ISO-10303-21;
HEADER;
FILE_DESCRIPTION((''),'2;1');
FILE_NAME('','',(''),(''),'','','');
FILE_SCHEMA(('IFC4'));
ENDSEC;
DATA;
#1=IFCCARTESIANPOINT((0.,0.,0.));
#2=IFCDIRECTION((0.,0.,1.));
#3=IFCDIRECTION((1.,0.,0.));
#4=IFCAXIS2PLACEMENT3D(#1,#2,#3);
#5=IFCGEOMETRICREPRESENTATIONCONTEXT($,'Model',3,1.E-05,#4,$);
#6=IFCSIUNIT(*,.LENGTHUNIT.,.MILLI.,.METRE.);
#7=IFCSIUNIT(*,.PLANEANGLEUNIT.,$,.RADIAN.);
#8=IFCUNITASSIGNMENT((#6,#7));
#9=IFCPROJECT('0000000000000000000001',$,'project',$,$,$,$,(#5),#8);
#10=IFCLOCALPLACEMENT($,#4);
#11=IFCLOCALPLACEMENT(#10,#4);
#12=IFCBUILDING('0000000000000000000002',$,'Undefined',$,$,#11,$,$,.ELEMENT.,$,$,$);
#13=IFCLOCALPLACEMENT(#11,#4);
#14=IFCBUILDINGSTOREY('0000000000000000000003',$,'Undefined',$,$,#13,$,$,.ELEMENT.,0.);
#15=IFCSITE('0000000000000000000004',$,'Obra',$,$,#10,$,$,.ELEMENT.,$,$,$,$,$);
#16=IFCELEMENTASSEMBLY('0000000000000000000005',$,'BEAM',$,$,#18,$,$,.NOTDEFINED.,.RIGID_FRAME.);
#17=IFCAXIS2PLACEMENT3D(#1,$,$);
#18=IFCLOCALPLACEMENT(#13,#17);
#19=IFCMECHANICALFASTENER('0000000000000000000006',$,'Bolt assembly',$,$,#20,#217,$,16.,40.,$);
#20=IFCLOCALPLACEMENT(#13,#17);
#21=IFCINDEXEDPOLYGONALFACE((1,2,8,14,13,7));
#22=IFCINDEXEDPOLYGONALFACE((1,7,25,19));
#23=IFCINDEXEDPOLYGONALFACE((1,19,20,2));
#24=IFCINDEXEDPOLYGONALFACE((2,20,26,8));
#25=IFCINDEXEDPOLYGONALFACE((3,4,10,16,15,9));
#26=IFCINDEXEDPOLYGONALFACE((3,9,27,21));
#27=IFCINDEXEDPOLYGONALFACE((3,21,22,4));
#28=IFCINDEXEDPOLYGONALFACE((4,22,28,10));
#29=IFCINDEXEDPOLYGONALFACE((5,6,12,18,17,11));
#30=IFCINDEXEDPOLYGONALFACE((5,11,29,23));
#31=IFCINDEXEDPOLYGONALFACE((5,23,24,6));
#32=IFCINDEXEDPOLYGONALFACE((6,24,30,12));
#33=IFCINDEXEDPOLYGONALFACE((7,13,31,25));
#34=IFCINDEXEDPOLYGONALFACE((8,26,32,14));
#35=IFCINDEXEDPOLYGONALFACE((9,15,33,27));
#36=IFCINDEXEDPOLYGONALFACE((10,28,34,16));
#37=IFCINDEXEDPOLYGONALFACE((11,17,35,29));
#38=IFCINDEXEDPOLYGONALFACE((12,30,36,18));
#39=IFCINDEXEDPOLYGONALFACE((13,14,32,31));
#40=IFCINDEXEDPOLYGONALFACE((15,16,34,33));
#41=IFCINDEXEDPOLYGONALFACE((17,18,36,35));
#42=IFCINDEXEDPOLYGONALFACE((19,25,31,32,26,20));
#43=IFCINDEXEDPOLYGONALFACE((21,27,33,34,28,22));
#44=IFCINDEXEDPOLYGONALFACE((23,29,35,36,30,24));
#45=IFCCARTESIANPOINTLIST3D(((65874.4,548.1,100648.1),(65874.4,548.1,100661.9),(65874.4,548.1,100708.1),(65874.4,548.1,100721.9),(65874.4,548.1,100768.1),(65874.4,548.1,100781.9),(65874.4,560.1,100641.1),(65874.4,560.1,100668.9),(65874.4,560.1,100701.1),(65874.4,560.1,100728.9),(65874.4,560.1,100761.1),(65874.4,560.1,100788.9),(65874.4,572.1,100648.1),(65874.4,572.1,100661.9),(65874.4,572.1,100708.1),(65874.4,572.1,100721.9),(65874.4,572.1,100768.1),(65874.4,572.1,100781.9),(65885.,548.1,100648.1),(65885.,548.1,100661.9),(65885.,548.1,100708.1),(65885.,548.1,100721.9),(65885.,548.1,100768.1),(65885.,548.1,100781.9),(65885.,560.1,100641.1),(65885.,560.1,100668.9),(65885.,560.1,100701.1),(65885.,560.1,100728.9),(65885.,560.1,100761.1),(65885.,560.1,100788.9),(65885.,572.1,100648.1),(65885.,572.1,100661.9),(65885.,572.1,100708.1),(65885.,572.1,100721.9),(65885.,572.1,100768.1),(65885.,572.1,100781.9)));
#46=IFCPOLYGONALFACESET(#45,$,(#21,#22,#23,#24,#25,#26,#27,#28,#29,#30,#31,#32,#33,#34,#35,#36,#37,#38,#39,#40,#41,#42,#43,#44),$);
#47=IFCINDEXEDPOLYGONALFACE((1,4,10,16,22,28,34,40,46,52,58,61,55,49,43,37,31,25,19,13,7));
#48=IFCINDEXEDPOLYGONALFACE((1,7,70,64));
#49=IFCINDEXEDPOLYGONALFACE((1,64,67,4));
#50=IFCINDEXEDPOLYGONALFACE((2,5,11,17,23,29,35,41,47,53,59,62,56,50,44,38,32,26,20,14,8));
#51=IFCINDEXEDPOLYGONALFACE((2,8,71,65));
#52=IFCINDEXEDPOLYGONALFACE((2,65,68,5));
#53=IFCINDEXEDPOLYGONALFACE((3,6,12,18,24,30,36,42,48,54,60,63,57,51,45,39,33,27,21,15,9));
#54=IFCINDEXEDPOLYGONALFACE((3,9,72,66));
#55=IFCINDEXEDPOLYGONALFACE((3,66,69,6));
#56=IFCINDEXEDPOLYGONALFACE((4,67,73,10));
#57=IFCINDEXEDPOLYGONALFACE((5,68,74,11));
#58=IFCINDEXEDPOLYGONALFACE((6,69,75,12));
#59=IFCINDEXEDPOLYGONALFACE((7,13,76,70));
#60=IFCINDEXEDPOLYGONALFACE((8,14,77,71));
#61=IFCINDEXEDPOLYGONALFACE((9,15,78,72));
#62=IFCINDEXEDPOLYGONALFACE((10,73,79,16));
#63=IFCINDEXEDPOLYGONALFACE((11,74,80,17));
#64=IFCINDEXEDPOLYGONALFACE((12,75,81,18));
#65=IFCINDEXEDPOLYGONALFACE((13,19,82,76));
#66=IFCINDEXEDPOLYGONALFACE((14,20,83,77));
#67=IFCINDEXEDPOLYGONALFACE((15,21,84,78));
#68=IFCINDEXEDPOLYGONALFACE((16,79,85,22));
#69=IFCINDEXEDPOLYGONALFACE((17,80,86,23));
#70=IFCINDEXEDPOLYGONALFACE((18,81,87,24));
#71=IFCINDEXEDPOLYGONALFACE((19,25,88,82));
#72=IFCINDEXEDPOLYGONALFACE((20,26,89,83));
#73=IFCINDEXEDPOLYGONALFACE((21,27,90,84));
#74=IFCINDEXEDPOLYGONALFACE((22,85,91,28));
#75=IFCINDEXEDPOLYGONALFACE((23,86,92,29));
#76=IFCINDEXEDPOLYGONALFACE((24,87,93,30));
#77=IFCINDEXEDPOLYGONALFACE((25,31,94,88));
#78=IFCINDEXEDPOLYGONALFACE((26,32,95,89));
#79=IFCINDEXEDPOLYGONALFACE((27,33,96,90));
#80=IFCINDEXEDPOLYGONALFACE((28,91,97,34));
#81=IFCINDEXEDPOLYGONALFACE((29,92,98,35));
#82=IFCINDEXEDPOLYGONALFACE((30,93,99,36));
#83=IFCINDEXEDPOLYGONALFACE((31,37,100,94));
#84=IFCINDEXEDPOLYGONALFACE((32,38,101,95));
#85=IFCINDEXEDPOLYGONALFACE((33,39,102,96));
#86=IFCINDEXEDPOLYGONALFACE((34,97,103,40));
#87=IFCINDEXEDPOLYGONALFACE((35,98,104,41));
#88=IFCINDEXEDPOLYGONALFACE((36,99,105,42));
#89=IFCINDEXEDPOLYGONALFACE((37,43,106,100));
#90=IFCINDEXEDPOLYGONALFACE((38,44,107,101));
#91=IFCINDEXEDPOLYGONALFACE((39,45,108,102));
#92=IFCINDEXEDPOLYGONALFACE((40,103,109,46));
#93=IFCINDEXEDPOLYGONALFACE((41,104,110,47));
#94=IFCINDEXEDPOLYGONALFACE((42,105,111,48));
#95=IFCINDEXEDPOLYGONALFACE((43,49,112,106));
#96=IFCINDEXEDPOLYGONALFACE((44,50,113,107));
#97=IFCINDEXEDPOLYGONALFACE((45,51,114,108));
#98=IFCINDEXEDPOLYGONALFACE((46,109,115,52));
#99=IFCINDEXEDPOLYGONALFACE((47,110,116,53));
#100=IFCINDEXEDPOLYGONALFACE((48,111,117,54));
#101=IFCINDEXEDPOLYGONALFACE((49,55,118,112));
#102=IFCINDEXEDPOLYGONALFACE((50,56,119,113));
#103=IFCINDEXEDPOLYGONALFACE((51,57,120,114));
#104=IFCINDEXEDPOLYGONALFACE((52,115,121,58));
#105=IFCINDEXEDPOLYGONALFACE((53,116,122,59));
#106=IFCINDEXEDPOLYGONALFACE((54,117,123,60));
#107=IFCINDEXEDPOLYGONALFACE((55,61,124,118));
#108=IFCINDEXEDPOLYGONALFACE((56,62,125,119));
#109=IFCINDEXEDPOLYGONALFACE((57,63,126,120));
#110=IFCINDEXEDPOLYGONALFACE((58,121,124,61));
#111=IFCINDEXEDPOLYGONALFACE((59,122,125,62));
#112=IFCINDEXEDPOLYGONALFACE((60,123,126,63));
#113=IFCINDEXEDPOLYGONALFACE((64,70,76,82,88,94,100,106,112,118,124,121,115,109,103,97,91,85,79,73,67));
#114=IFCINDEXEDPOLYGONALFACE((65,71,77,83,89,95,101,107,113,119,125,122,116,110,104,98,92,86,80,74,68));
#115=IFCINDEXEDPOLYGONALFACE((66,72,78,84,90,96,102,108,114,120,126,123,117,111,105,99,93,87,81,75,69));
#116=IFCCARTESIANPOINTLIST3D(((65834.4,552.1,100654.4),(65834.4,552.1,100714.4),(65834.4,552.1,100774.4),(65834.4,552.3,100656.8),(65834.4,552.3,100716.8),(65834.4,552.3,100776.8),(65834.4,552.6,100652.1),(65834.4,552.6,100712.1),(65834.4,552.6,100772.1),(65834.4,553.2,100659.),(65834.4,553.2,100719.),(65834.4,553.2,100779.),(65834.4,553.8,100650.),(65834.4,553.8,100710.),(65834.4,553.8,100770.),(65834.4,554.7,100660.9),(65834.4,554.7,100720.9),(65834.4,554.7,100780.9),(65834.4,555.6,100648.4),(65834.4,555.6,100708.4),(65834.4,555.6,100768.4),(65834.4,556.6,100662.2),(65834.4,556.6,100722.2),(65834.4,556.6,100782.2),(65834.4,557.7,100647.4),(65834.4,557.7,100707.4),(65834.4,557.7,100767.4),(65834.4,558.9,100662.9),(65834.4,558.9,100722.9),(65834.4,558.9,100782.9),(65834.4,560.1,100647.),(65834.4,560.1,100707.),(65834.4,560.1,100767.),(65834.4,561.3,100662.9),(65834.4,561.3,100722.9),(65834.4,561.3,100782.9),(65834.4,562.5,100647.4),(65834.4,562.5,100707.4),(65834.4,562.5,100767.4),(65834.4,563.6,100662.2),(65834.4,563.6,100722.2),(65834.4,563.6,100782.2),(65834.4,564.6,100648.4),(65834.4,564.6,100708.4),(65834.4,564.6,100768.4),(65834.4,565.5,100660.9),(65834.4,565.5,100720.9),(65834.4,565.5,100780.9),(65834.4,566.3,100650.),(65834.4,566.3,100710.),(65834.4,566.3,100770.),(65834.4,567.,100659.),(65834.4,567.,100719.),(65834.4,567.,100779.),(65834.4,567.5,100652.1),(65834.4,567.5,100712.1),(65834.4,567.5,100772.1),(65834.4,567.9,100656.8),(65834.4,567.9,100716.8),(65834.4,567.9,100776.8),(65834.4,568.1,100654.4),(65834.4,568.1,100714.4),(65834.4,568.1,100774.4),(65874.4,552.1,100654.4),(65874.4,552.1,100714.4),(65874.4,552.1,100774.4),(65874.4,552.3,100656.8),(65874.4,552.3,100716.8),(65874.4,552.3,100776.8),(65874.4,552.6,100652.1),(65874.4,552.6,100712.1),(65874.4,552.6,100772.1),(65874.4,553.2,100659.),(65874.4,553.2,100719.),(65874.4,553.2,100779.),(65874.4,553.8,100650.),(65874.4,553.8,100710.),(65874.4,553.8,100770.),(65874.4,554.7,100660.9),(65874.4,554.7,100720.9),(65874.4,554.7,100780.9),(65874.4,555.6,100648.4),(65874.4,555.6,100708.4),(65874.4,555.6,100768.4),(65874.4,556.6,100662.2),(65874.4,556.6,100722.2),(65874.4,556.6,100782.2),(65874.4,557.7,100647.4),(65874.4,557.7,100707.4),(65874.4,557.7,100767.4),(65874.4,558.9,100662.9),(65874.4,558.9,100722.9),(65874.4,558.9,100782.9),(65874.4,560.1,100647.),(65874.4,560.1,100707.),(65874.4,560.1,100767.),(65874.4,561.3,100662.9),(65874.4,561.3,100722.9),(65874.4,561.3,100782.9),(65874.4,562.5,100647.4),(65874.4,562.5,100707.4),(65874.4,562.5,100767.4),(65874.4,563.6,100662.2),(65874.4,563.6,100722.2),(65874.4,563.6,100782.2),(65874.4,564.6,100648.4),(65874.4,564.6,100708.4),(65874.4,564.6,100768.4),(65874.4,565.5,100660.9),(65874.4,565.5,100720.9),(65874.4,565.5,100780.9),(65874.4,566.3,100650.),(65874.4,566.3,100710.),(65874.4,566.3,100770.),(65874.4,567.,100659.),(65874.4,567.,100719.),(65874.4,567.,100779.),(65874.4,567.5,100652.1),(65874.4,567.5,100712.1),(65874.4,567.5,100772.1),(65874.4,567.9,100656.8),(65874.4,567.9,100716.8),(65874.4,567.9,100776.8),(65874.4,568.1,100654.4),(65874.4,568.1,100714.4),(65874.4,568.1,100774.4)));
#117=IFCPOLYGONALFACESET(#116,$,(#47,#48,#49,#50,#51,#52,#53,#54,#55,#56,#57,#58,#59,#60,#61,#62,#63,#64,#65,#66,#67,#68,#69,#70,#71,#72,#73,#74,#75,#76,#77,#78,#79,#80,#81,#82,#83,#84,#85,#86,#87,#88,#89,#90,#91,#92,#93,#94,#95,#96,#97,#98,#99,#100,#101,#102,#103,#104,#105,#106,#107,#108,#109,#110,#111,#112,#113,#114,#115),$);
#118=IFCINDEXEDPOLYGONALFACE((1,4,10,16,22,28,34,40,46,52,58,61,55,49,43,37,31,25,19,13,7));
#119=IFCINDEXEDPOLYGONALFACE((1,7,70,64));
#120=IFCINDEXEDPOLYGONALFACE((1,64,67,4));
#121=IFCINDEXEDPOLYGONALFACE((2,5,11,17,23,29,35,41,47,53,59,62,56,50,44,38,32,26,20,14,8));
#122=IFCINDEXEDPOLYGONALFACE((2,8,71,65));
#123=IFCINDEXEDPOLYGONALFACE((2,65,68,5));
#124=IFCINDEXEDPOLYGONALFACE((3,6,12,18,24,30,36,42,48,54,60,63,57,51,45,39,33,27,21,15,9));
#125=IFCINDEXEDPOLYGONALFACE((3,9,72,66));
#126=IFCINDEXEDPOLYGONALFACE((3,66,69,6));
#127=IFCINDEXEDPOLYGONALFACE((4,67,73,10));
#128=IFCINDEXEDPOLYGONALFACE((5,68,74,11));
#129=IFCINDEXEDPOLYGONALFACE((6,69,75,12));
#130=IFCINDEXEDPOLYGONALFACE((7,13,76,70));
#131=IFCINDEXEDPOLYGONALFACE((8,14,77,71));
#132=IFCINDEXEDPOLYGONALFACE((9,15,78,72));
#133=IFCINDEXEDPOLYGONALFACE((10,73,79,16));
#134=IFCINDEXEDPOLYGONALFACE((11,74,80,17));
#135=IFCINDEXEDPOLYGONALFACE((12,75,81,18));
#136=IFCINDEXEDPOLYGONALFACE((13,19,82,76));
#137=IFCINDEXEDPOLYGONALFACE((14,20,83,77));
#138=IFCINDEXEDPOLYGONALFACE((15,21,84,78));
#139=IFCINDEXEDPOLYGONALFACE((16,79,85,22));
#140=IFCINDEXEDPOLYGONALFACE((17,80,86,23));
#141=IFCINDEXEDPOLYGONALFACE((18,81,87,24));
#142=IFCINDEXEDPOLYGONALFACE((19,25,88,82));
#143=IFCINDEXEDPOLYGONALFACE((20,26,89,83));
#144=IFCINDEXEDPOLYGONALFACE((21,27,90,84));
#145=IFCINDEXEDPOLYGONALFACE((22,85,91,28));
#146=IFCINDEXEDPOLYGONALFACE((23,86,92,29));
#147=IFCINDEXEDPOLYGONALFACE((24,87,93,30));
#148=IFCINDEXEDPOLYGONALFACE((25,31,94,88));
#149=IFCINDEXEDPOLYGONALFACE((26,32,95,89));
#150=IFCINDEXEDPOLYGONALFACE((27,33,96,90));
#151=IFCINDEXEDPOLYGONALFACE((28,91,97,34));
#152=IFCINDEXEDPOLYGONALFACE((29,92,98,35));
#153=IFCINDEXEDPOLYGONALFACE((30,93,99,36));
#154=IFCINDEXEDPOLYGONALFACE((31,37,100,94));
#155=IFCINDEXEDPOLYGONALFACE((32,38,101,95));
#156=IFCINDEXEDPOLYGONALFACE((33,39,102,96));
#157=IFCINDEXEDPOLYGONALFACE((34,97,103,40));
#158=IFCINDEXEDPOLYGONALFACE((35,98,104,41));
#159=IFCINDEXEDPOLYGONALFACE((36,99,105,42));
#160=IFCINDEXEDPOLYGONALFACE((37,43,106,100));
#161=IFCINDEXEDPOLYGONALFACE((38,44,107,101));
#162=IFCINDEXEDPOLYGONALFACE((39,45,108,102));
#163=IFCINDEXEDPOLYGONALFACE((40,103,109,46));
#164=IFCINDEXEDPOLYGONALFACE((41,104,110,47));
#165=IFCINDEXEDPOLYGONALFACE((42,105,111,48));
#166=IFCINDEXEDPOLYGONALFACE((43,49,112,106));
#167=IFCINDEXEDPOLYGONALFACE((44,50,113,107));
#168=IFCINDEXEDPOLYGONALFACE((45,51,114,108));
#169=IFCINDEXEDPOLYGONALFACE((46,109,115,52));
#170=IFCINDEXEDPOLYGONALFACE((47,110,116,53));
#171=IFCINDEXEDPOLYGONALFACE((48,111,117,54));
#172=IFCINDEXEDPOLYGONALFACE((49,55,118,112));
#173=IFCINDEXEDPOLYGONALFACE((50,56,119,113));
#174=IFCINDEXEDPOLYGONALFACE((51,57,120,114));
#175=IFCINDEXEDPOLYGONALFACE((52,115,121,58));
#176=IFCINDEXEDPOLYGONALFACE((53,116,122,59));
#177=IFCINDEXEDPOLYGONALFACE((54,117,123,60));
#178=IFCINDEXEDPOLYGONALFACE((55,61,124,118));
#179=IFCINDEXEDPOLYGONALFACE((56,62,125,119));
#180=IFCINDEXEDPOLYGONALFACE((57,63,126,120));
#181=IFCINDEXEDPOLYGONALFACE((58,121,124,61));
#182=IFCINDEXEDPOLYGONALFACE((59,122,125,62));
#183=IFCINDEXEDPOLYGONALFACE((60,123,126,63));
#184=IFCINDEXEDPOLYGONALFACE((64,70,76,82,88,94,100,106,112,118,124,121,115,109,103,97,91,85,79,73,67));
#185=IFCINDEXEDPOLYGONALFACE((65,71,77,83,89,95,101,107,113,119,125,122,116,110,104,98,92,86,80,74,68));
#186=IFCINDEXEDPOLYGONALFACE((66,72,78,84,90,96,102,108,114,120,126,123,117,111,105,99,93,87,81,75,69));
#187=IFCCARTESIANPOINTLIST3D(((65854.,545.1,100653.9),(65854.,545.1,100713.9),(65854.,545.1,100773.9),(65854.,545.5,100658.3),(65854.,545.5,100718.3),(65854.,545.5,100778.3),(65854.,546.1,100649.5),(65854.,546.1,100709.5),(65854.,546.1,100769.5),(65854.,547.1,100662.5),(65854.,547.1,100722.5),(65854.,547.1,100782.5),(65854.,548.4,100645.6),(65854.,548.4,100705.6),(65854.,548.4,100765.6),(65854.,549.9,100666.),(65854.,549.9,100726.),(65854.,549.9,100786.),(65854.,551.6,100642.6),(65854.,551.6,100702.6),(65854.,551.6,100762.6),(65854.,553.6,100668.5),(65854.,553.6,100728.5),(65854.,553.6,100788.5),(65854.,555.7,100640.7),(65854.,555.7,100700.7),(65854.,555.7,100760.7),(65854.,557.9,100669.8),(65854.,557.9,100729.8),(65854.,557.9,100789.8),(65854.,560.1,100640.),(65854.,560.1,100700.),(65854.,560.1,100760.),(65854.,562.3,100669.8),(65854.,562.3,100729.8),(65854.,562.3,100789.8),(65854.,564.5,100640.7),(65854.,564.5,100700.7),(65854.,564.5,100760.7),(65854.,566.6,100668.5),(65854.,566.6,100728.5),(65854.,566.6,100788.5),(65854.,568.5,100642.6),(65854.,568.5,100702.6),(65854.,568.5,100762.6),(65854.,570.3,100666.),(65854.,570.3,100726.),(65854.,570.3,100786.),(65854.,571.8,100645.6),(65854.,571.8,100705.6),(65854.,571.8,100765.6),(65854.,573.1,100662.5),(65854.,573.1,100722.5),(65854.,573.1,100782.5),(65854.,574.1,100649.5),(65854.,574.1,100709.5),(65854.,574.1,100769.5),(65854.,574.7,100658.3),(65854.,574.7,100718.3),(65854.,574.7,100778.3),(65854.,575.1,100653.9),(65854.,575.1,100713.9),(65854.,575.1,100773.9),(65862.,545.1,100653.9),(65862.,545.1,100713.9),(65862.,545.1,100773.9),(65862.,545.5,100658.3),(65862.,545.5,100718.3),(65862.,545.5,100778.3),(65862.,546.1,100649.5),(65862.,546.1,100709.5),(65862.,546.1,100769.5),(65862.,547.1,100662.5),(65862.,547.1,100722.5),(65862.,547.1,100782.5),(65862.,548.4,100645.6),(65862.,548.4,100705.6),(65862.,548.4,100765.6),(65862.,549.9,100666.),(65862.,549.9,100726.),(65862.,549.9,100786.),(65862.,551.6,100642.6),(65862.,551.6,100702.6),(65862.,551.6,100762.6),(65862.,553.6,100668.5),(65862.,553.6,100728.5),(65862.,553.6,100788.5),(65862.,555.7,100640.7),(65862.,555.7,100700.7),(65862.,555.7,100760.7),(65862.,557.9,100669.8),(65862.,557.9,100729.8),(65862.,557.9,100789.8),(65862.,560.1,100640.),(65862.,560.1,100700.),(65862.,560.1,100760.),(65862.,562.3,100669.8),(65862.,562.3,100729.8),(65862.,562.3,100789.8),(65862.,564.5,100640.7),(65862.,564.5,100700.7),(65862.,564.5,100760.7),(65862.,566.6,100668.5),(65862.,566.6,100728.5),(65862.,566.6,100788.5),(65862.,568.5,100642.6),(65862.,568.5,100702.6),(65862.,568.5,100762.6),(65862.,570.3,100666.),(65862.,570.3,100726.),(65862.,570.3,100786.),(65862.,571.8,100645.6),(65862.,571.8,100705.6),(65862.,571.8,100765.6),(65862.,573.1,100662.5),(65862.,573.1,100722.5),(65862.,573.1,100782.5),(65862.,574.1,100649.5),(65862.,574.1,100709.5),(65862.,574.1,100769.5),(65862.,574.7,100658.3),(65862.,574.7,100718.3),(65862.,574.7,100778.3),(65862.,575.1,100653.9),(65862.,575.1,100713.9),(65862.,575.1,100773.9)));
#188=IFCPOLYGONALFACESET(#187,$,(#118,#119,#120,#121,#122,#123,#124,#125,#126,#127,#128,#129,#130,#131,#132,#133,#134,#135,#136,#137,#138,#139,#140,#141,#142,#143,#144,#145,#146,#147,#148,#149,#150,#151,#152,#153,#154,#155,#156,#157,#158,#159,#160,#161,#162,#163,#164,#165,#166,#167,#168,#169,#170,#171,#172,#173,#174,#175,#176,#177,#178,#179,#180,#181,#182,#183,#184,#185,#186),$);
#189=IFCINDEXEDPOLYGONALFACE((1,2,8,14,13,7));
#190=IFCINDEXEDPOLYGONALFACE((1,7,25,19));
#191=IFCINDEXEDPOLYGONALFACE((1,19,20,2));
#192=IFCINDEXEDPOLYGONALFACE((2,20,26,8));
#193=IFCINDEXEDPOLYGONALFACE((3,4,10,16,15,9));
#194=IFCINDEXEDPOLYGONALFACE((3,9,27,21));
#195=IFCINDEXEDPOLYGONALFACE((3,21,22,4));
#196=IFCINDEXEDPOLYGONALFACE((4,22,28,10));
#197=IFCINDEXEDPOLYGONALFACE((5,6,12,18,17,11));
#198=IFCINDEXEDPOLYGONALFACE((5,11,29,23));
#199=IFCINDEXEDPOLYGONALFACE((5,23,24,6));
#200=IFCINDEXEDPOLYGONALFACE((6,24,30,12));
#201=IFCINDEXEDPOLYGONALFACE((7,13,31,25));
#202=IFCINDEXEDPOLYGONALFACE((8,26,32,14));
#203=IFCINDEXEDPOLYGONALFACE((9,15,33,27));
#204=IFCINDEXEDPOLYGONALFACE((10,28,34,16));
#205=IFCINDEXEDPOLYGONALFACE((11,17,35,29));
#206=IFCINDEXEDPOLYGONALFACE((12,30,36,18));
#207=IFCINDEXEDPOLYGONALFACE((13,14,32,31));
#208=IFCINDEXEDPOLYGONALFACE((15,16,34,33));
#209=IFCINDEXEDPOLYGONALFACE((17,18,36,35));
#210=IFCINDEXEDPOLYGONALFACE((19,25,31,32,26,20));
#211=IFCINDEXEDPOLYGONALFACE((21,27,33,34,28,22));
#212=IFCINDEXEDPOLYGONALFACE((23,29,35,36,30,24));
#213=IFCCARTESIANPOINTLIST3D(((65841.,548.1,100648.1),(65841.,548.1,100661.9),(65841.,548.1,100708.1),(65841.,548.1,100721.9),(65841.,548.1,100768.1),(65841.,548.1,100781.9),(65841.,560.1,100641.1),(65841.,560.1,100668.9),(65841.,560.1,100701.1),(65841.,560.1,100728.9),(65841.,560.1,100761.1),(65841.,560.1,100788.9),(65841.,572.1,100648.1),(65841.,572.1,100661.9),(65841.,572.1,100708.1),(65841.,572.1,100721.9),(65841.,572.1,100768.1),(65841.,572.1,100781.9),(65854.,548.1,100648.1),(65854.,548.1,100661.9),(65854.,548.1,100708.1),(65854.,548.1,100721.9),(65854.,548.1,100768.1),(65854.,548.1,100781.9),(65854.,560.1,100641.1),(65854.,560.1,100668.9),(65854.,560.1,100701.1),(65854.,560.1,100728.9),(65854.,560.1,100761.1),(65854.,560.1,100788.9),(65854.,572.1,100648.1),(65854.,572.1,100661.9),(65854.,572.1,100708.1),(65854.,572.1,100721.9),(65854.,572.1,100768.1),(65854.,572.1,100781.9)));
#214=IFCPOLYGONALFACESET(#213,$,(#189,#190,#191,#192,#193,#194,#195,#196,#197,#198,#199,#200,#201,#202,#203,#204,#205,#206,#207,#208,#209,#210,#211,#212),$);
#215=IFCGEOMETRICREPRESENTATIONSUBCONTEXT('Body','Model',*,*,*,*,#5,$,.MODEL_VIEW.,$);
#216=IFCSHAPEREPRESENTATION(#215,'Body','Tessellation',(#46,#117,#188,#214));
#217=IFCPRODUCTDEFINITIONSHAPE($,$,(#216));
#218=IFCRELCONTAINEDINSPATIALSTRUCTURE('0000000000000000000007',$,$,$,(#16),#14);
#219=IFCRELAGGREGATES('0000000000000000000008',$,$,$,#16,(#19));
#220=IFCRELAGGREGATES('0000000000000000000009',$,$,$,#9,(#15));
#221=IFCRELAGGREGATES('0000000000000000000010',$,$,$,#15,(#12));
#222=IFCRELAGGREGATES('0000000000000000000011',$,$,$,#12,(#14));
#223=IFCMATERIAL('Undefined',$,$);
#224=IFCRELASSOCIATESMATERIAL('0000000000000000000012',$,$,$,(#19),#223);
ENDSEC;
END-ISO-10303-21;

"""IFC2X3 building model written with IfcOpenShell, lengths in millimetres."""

from ifc_helpers import new_model, si_unit, frame, origin_with_axes, origin_2d_with_axis, place, context, subcontext, project, spatial, polyline, circle, outline, extrude, source, transform, mapped, material, element, aggregate, save


model = new_model("IFC2X3")

# Units and contexts
model_context = context("Model", 3, precision=1e-05, world=origin_with_axes())
body_context = subcontext(model_context, "Body", "Model", "MODEL_VIEW")
ifc_project = project(units=[si_unit("LENGTHUNIT", "METRE", prefix="MILLI"), si_unit("PLANEANGLEUNIT", "RADIAN")], contexts=[model_context])

# Site, building, storey
site_placement = place(None, origin_with_axes())
site = spatial("IfcSite", under=ifc_project, at=site_placement, Name="Obra", CompositionType="ELEMENT")
building_placement = place(site_placement, origin_with_axes())
building = spatial("IfcBuilding", under=site, at=building_placement, Name="Undefined", CompositionType="ELEMENT")
storey_placement = place(building_placement, origin_with_axes())
storey = spatial("IfcBuildingStorey", under=building, at=storey_placement, Name="Undefined", CompositionType="ELEMENT", Elevation=0.0)

# Shared definitions
ifc_material_1 = material(Name="Undefined")

# Element assembly, mechanical fastener
assembly_1_placement = place(storey_placement, origin_with_axes())
assembly_1 = element("IfcElementAssembly", 1, at=assembly_1_placement, inside=storey, Name="BEAM", AssemblyPlace="NOTDEFINED", PredefinedType="RIGID_FRAME")
shared_shape_1 = source(origin_with_axes(), body_context, "Body", "SweptSolid", [
    extrude(outline(polyline([(13.9, 0.0), (6.9, 12.0), (-6.9, 12.0), (-13.9, 0.0), (-6.9, -12.0), (6.9, -12.0), (13.9, 0.0)])), frame((0.0, -19.7, 0.0), z_axis=(0.0, 1.0, 0.0), x_axis=(1.0, 0.0, 0.0)), (0.0, 0.0, 1.0), 10.6),
    extrude(circle(Radius=8.0, at=origin_2d_with_axis()), frame((0.0, -9.1, 0.0), z_axis=(0.0, 1.0, 0.0), x_axis=(1.0, 0.0, 0.0)), (0.0, 0.0, 1.0), 40.0),
    extrude(circle(Radius=15.0, at=origin_2d_with_axis()), frame((0.0, 3.3, 0.0), z_axis=(0.0, 1.0, 0.0), x_axis=(1.0, 0.0, 0.0)), (0.0, 0.0, 1.0), 8.0),
    extrude(outline(polyline([(13.9, 0.0), (6.9, 12.0), (-6.9, 12.0), (-13.9, 0.0), (-6.9, -12.0), (6.9, -12.0), (13.9, 0.0)])), frame((0.0, 11.3, 0.0), z_axis=(0.0, 1.0, 0.0), x_axis=(1.0, 0.0, 0.0)), (0.0, 0.0, 1.0), 13.0),
])
mechanical_fastener_1_placement = place(assembly_1_placement, frame((65865.3, 510.1, 100835.0), z_axis=(-0.000002, 1.0, 0.0), x_axis=(0.0, 0.0, -1.0)))
mechanical_fastener_1 = element("IfcMechanicalFastener", 2, at=mechanical_fastener_1_placement, material=ifc_material_1, Name="Bolt assembly", NominalDiameter=16.0, NominalLength=40.0, context=body_context, shape_type="MappedRepresentation", body=[
    mapped(shared_shape_1, transform((60.0, 0.0, 50.0))),
    mapped(shared_shape_1, transform((120.0, 0.0, 50.0))),
    mapped(shared_shape_1, transform((180.0, 0.0, 50.0))),
])

aggregate(assembly_1, [mechanical_fastener_1])

save(model, "model.ifc")
